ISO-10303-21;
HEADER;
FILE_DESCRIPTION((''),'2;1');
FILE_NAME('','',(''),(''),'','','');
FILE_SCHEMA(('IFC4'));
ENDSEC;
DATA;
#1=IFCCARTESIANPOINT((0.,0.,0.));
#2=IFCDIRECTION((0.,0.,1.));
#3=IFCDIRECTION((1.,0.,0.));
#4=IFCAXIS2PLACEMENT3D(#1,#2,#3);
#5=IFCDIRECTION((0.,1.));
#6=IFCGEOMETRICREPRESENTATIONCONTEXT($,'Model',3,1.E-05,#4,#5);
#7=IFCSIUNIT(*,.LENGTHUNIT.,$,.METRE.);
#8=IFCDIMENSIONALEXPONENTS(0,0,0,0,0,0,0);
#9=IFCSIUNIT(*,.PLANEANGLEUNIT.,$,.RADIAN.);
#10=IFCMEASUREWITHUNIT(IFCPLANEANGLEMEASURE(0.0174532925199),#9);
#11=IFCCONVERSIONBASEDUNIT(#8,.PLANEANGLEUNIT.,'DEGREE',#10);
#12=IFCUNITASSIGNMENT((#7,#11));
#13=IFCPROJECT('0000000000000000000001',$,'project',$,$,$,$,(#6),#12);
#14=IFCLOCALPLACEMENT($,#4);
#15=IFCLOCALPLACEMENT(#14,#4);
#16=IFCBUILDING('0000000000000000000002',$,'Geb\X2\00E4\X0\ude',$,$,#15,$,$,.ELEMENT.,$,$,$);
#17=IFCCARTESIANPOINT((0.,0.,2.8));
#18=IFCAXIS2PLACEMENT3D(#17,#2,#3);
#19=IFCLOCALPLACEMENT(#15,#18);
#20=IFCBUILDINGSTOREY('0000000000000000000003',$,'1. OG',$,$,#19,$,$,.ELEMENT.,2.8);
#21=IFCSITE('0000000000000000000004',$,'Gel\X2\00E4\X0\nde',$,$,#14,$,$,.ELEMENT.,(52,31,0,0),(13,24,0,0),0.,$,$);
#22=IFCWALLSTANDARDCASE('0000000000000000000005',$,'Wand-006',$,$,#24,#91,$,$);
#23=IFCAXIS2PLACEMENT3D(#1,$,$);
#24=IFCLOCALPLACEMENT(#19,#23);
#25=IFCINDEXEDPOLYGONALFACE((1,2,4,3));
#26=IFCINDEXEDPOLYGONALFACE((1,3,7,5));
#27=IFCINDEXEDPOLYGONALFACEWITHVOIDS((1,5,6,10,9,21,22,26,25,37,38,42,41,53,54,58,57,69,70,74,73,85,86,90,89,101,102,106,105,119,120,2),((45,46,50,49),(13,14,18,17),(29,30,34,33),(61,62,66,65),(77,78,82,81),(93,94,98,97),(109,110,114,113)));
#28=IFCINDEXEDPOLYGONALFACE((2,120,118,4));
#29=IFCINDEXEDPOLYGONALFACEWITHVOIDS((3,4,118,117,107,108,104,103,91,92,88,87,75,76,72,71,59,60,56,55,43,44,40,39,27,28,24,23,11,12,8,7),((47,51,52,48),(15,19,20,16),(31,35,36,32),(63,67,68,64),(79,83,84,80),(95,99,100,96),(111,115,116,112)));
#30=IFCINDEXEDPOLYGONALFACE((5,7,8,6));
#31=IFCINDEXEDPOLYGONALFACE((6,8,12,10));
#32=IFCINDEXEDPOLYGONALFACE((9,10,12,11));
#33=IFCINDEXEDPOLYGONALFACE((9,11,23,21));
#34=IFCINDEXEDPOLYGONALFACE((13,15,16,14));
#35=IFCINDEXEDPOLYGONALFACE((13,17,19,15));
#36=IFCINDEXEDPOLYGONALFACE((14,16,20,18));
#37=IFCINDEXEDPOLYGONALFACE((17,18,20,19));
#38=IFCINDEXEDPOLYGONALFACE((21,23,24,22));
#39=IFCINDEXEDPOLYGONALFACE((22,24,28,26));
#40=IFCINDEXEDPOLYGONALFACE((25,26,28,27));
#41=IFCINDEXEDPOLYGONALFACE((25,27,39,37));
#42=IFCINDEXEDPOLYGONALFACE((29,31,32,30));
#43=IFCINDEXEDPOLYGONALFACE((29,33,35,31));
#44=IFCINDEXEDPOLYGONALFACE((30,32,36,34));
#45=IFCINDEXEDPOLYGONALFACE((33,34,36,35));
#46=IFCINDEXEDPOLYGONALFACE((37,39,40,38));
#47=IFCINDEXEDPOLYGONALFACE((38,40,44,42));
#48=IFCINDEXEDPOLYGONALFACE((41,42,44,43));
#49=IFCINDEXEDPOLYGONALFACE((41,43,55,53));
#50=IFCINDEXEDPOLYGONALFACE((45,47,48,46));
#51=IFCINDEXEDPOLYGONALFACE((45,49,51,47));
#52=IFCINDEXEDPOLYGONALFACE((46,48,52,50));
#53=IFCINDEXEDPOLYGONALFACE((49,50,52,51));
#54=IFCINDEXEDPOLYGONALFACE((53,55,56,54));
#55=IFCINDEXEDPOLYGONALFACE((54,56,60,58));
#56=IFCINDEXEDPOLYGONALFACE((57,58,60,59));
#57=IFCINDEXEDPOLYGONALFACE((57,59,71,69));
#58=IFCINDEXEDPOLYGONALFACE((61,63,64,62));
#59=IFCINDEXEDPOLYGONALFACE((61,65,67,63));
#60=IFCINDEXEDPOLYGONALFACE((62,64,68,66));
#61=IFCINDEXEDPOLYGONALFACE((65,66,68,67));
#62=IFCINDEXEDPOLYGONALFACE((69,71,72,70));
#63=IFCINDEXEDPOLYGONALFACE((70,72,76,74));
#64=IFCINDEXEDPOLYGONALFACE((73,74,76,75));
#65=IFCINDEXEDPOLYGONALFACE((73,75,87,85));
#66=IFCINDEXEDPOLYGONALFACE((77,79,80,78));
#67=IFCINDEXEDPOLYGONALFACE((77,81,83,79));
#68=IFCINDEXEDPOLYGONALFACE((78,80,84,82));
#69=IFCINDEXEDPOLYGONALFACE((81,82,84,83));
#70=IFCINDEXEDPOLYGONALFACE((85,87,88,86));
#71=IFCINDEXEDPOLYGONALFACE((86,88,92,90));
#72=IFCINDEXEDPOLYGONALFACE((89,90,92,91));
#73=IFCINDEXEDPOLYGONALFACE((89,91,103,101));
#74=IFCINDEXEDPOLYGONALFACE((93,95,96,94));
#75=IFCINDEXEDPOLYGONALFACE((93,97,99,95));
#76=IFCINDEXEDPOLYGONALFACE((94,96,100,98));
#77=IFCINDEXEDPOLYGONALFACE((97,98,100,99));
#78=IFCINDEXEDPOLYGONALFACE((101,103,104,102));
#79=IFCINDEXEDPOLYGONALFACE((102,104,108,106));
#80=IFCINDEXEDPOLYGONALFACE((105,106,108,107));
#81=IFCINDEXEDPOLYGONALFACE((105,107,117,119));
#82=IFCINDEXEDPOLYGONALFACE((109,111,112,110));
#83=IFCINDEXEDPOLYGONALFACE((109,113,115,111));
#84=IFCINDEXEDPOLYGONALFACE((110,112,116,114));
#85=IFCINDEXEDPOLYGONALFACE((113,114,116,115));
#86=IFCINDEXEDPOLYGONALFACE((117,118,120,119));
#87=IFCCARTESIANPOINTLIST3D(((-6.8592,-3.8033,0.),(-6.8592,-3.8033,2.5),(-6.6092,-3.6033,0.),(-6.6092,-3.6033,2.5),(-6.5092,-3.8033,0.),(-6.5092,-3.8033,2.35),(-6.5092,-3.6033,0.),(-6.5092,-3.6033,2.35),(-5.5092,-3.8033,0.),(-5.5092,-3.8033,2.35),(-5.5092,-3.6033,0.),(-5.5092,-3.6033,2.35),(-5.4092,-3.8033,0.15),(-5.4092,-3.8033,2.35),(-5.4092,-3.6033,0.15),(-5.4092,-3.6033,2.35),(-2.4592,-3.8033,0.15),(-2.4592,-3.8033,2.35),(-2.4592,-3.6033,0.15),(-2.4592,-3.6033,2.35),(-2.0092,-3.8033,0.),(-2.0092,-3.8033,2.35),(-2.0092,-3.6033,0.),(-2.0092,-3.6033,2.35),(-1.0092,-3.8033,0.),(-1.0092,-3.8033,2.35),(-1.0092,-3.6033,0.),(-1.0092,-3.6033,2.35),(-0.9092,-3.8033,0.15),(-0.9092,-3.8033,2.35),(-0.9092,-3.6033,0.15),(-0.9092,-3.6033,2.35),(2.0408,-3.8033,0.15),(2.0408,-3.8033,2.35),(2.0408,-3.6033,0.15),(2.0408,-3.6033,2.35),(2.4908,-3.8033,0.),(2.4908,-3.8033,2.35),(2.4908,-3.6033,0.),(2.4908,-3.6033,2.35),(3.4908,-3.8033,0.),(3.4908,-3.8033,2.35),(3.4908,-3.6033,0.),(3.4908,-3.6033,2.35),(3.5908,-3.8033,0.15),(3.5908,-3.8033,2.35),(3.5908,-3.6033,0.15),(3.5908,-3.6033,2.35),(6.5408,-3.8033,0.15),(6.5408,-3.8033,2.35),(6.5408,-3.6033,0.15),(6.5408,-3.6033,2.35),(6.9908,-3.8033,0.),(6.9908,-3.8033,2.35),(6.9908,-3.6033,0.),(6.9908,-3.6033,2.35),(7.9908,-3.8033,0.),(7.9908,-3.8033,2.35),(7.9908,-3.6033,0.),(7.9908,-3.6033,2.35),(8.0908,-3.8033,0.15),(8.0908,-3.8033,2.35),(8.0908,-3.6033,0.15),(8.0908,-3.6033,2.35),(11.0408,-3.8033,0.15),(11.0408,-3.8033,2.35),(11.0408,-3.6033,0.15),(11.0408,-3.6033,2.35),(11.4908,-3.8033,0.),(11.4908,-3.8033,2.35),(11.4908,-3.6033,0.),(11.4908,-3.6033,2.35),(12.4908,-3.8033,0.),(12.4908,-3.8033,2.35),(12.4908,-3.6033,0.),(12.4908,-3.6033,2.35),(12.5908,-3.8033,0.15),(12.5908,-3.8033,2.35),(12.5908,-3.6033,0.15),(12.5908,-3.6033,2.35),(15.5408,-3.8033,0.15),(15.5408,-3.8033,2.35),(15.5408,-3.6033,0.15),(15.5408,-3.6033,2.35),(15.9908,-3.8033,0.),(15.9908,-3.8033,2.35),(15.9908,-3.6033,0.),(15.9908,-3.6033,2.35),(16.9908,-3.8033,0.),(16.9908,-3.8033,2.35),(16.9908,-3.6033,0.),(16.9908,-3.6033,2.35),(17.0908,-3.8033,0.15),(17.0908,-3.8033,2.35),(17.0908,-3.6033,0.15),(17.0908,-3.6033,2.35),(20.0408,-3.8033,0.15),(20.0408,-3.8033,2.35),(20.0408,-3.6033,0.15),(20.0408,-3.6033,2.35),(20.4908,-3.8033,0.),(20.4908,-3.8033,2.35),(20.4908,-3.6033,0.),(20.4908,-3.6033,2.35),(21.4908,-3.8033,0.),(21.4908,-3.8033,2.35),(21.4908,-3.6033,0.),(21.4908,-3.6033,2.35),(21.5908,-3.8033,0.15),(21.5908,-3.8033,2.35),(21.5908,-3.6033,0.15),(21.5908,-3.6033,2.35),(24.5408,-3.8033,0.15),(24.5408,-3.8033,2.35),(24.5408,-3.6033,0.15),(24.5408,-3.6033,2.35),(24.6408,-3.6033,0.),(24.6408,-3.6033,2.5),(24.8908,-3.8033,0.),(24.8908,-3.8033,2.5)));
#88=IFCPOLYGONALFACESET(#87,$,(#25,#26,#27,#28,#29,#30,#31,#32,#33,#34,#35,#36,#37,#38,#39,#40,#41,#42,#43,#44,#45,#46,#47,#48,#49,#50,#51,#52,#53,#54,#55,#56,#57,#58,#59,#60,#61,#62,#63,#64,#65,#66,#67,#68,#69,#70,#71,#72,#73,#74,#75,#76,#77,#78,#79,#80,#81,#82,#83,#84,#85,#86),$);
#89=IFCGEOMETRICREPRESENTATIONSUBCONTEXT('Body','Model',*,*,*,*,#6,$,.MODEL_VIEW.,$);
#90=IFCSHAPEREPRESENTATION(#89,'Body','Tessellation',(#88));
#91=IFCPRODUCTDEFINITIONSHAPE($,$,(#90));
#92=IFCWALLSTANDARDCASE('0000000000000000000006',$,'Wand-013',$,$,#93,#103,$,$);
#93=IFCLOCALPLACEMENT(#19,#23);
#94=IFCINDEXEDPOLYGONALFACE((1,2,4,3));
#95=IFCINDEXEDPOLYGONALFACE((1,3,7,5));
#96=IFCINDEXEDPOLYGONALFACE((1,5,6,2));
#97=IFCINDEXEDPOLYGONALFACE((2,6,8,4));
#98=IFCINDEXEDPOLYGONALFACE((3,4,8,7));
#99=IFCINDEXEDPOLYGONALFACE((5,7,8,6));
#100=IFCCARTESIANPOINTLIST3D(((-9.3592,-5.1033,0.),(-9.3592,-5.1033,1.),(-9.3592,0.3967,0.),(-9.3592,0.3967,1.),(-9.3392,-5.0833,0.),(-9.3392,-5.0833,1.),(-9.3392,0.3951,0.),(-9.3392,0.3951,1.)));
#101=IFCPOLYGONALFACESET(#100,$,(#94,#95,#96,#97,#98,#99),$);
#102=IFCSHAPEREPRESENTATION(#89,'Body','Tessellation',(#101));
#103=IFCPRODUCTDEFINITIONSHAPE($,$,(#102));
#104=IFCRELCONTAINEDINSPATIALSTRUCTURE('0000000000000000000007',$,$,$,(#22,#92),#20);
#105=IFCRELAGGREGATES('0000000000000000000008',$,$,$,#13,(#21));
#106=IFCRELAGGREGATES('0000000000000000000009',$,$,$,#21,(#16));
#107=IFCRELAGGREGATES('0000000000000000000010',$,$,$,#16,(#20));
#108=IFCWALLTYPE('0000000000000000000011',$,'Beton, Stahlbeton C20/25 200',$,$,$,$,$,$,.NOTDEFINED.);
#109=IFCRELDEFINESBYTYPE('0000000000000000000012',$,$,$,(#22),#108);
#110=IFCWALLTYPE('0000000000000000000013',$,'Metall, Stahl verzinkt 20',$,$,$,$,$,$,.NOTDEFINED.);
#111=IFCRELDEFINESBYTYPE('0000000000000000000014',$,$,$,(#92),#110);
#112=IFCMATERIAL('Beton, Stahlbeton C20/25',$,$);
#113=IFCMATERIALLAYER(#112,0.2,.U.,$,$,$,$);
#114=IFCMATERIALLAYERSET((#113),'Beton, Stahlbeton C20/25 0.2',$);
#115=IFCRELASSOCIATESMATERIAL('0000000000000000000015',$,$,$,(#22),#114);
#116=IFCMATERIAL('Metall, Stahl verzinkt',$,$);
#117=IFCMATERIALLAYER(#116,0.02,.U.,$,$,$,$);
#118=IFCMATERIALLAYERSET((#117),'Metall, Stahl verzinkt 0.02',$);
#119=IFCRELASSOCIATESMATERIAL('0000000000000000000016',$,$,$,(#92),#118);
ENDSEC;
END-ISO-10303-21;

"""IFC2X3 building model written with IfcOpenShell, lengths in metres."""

from ifc_helpers import new_model, entity, si_unit, converted_unit, direction, frame, origin_with_axes, origin_2d_with_axis, place, context, subcontext, project, spatial, polyline, rectangle, outline, extrude, material, layer, layer_set, layer_usage, type_object, element, save


model = new_model("IFC2X3")

# Units and contexts
model_context = context("Model", 3, precision=1e-05, world=origin_with_axes(), true_north=direction((0.0, 1.0)))
body_context = subcontext(model_context, "Body", "Model", "MODEL_VIEW")
ifc_project = project(units=[si_unit("LENGTHUNIT", "METRE"), converted_unit("PLANEANGLEUNIT", "DEGREE", entity("IfcPlaneAngleMeasure", 0.0174532925199), si_unit("PLANEANGLEUNIT", "RADIAN"), dimensions=[0, 0, 0, 0, 0, 0, 0])], contexts=[model_context])

# Site, building, storey
site_placement = place(None, origin_with_axes())
site = spatial("IfcSite", under=ifc_project, at=site_placement, Name="Gelände", CompositionType="ELEMENT", RefLatitude=(52, 31, 0, 0), RefLongitude=(13, 24, 0, 0), RefElevation=0.0)
building_placement = place(site_placement, origin_with_axes())
building = spatial("IfcBuilding", under=site, at=building_placement, Name="Gebäude", CompositionType="ELEMENT")
storey_placement = place(building_placement, frame((0.0, 0.0, 2.8), z_axis=(0.0, 0.0, 1.0), x_axis=(1.0, 0.0, 0.0)))
storey = spatial("IfcBuildingStorey", under=building, at=storey_placement, Name="1. OG", CompositionType="ELEMENT", Elevation=2.8)

# Shared definitions
ifc_material_1 = material(Name="Beton, Stahlbeton C20/25")

# Wall, openings
ifc_layer_1 = layer(ifc_material_1, 0.2, ventilated="UNKNOWN")
ifc_layer_set_1 = layer_set([ifc_layer_1], Name="Beton, Stahlbeton C20/25 0.2")
ifc_layer_usage_1 = layer_usage(ifc_layer_set_1, "AXIS2", "NEGATIVE", 0.0)
wall_type_1 = type_object("IfcWallType", Name="Beton, Stahlbeton C20/25 200", PredefinedType="NOTDEFINED")
wall_1_placement = place(storey_placement, frame((-6.6092, -3.6033, 0.0), z_axis=(0.0, 0.0, 1.0), x_axis=(1.0, 0.0, 0.0)))
wall_1 = element("IfcWallStandardCase", 1, at=wall_1_placement, inside=storey, type_object=wall_type_1, material=ifc_layer_usage_1, Name="Wand-006", context=body_context, shape_type="SweptSolid", body=[
    extrude(outline(polyline([(-0.25, -0.2), (31.5, -0.2), (31.25, 0.0), (0.0, 0.0), (-0.25, -0.2)])), origin_with_axes(), (0.0, 0.0, 1.0), 2.5),
])
opening_1_placement = place(wall_1_placement, frame((23.1, 0.0, 0.0), z_axis=(0.0, 0.0, 1.0), x_axis=(1.0, 0.0, 0.0)))
element("IfcOpeningElement", 2, at=opening_1_placement, cuts=wall_1, context=body_context, shape_type="SweptSolid", body=[
    extrude(rectangle(XDim=1.0, YDim=2.35, at=origin_2d_with_axis()), frame((0.0, -0.4, 1.175), z_axis=(0.0, 1.0, 0.0), x_axis=(-1.0, 0.0, 0.0)), (0.0, 0.0, 1.0), 0.6),
])
opening_2_placement = place(wall_1_placement, frame((29.675, 0.0, 0.15), z_axis=(0.0, 0.0, 1.0), x_axis=(1.0, 0.0, 0.0)))
element("IfcOpeningElement", 3, at=opening_2_placement, cuts=wall_1, context=body_context, shape_type="SweptSolid", body=[
    extrude(rectangle(XDim=2.95, YDim=2.2, at=origin_2d_with_axis()), frame((0.0, 0.2, 1.1), z_axis=(0.0, -1.0, 0.0), x_axis=(1.0, 0.0, 0.0)), (0.0, 0.0, 1.0), 0.6),
])
opening_3_placement = place(wall_1_placement, frame((5.1, 0.0, 0.0), z_axis=(0.0, 0.0, 1.0), x_axis=(1.0, 0.0, 0.0)))
element("IfcOpeningElement", 4, at=opening_3_placement, cuts=wall_1, context=body_context, shape_type="SweptSolid", body=[
    extrude(rectangle(XDim=1.0, YDim=2.35, at=origin_2d_with_axis()), frame((0.0, -0.4, 1.175), z_axis=(0.0, 1.0, 0.0), x_axis=(-1.0, 0.0, 0.0)), (0.0, 0.0, 1.0), 0.6),
])
opening_4_placement = place(wall_1_placement, frame((11.675, 0.0, 0.15), z_axis=(0.0, 0.0, 1.0), x_axis=(1.0, 0.0, 0.0)))
element("IfcOpeningElement", 5, at=opening_4_placement, cuts=wall_1, context=body_context, shape_type="SweptSolid", body=[
    extrude(rectangle(XDim=2.95, YDim=2.2, at=origin_2d_with_axis()), frame((0.0, 0.2, 1.1), z_axis=(0.0, -1.0, 0.0), x_axis=(1.0, 0.0, 0.0)), (0.0, 0.0, 1.0), 0.6),
])
opening_5_placement = place(wall_1_placement, frame((7.175, 0.0, 0.15), z_axis=(0.0, 0.0, 1.0), x_axis=(1.0, 0.0, 0.0)))
element("IfcOpeningElement", 6, at=opening_5_placement, cuts=wall_1, context=body_context, shape_type="SweptSolid", body=[
    extrude(rectangle(XDim=2.95, YDim=2.2, at=origin_2d_with_axis()), frame((0.0, 0.2, 1.1), z_axis=(0.0, -1.0, 0.0), x_axis=(1.0, 0.0, 0.0)), (0.0, 0.0, 1.0), 0.6),
])
opening_6_placement = place(wall_1_placement, frame((9.6, 0.0, 0.0), z_axis=(0.0, 0.0, 1.0), x_axis=(1.0, 0.0, 0.0)))
element("IfcOpeningElement", 7, at=opening_6_placement, cuts=wall_1, context=body_context, shape_type="SweptSolid", body=[
    extrude(rectangle(XDim=1.0, YDim=2.35, at=origin_2d_with_axis()), frame((0.0, -0.4, 1.175), z_axis=(0.0, 1.0, 0.0), x_axis=(-1.0, 0.0, 0.0)), (0.0, 0.0, 1.0), 0.6),
])
opening_7_placement = place(wall_1_placement, frame((0.6, 0.0, 0.0), z_axis=(0.0, 0.0, 1.0), x_axis=(1.0, 0.0, 0.0)))
element("IfcOpeningElement", 8, at=opening_7_placement, cuts=wall_1, context=body_context, shape_type="SweptSolid", body=[
    extrude(rectangle(XDim=1.0, YDim=2.35, at=origin_2d_with_axis()), frame((0.0, -0.4, 1.175), z_axis=(0.0, 1.0, 0.0), x_axis=(-1.0, 0.0, 0.0)), (0.0, 0.0, 1.0), 0.6),
])
opening_8_placement = place(wall_1_placement, frame((14.1, 0.0, 0.0), z_axis=(0.0, 0.0, 1.0), x_axis=(1.0, 0.0, 0.0)))
element("IfcOpeningElement", 9, at=opening_8_placement, cuts=wall_1, context=body_context, shape_type="SweptSolid", body=[
    extrude(rectangle(XDim=1.0, YDim=2.35, at=origin_2d_with_axis()), frame((0.0, -0.4, 1.175), z_axis=(0.0, 1.0, 0.0), x_axis=(-1.0, 0.0, 0.0)), (0.0, 0.0, 1.0), 0.6),
])
opening_9_placement = place(wall_1_placement, frame((2.675, 0.0, 0.15), z_axis=(0.0, 0.0, 1.0), x_axis=(1.0, 0.0, 0.0)))
element("IfcOpeningElement", 10, at=opening_9_placement, cuts=wall_1, context=body_context, shape_type="SweptSolid", body=[
    extrude(rectangle(XDim=2.95, YDim=2.2, at=origin_2d_with_axis()), frame((0.0, 0.2, 1.1), z_axis=(0.0, -1.0, 0.0), x_axis=(1.0, 0.0, 0.0)), (0.0, 0.0, 1.0), 0.6),
])
opening_10_placement = place(wall_1_placement, frame((20.675, 0.0, 0.15), z_axis=(0.0, 0.0, 1.0), x_axis=(1.0, 0.0, 0.0)))
element("IfcOpeningElement", 11, at=opening_10_placement, cuts=wall_1, context=body_context, shape_type="SweptSolid", body=[
    extrude(rectangle(XDim=2.95, YDim=2.2, at=origin_2d_with_axis()), frame((0.0, 0.2, 1.1), z_axis=(0.0, -1.0, 0.0), x_axis=(1.0, 0.0, 0.0)), (0.0, 0.0, 1.0), 0.6),
])
opening_11_placement = place(wall_1_placement, frame((16.175, 0.0, 0.15), z_axis=(0.0, 0.0, 1.0), x_axis=(1.0, 0.0, 0.0)))
element("IfcOpeningElement", 12, at=opening_11_placement, cuts=wall_1, context=body_context, shape_type="SweptSolid", body=[
    extrude(rectangle(XDim=2.95, YDim=2.2, at=origin_2d_with_axis()), frame((0.0, 0.2, 1.1), z_axis=(0.0, -1.0, 0.0), x_axis=(1.0, 0.0, 0.0)), (0.0, 0.0, 1.0), 0.6),
])
opening_12_placement = place(wall_1_placement, frame((27.6, 0.0, 0.0), z_axis=(0.0, 0.0, 1.0), x_axis=(1.0, 0.0, 0.0)))
element("IfcOpeningElement", 13, at=opening_12_placement, cuts=wall_1, context=body_context, shape_type="SweptSolid", body=[
    extrude(rectangle(XDim=1.0, YDim=2.35, at=origin_2d_with_axis()), frame((0.0, -0.4, 1.175), z_axis=(0.0, 1.0, 0.0), x_axis=(-1.0, 0.0, 0.0)), (0.0, 0.0, 1.0), 0.6),
])
opening_13_placement = place(wall_1_placement, frame((18.6, 0.0, 0.0), z_axis=(0.0, 0.0, 1.0), x_axis=(1.0, 0.0, 0.0)))
element("IfcOpeningElement", 14, at=opening_13_placement, cuts=wall_1, context=body_context, shape_type="SweptSolid", body=[
    extrude(rectangle(XDim=1.0, YDim=2.35, at=origin_2d_with_axis()), frame((0.0, -0.4, 1.175), z_axis=(0.0, 1.0, 0.0), x_axis=(-1.0, 0.0, 0.0)), (0.0, 0.0, 1.0), 0.6),
])
opening_14_placement = place(wall_1_placement, frame((25.175, 0.0, 0.15), z_axis=(0.0, 0.0, 1.0), x_axis=(1.0, 0.0, 0.0)))
element("IfcOpeningElement", 15, at=opening_14_placement, cuts=wall_1, context=body_context, shape_type="SweptSolid", body=[
    extrude(rectangle(XDim=2.95, YDim=2.2, at=origin_2d_with_axis()), frame((0.0, 0.2, 1.1), z_axis=(0.0, -1.0, 0.0), x_axis=(1.0, 0.0, 0.0)), (0.0, 0.0, 1.0), 0.6),
])

# Wall
ifc_material_2 = material(Name="Metall, Stahl verzinkt")
ifc_layer_2 = layer(ifc_material_2, 0.02, ventilated="UNKNOWN")
ifc_layer_set_2 = layer_set([ifc_layer_2], Name="Metall, Stahl verzinkt 0.02")
ifc_layer_usage_2 = layer_usage(ifc_layer_set_2, "AXIS2", "NEGATIVE", 0.0)
wall_type_2 = type_object("IfcWallType", Name="Metall, Stahl verzinkt 20", PredefinedType="NOTDEFINED")
wall_2_placement = place(storey_placement, frame((-9.3592, -5.1033, 0.0), z_axis=(0.0, 0.0, 1.0), x_axis=(0.0, 1.0, 0.0)))
element("IfcWallStandardCase", 16, at=wall_2_placement, inside=storey, type_object=wall_type_2, material=ifc_layer_usage_2, Name="Wand-013", context=body_context, shape_type="SweptSolid", body=[
    extrude(outline(polyline([(0.02, -0.02), (5.4983, -0.02), (5.5, 0.0), (0.0, 0.0), (0.02, -0.02)])), origin_with_axes(), (0.0, 0.0, 1.0), 1.0),
])

save(model, "model.ifc")
